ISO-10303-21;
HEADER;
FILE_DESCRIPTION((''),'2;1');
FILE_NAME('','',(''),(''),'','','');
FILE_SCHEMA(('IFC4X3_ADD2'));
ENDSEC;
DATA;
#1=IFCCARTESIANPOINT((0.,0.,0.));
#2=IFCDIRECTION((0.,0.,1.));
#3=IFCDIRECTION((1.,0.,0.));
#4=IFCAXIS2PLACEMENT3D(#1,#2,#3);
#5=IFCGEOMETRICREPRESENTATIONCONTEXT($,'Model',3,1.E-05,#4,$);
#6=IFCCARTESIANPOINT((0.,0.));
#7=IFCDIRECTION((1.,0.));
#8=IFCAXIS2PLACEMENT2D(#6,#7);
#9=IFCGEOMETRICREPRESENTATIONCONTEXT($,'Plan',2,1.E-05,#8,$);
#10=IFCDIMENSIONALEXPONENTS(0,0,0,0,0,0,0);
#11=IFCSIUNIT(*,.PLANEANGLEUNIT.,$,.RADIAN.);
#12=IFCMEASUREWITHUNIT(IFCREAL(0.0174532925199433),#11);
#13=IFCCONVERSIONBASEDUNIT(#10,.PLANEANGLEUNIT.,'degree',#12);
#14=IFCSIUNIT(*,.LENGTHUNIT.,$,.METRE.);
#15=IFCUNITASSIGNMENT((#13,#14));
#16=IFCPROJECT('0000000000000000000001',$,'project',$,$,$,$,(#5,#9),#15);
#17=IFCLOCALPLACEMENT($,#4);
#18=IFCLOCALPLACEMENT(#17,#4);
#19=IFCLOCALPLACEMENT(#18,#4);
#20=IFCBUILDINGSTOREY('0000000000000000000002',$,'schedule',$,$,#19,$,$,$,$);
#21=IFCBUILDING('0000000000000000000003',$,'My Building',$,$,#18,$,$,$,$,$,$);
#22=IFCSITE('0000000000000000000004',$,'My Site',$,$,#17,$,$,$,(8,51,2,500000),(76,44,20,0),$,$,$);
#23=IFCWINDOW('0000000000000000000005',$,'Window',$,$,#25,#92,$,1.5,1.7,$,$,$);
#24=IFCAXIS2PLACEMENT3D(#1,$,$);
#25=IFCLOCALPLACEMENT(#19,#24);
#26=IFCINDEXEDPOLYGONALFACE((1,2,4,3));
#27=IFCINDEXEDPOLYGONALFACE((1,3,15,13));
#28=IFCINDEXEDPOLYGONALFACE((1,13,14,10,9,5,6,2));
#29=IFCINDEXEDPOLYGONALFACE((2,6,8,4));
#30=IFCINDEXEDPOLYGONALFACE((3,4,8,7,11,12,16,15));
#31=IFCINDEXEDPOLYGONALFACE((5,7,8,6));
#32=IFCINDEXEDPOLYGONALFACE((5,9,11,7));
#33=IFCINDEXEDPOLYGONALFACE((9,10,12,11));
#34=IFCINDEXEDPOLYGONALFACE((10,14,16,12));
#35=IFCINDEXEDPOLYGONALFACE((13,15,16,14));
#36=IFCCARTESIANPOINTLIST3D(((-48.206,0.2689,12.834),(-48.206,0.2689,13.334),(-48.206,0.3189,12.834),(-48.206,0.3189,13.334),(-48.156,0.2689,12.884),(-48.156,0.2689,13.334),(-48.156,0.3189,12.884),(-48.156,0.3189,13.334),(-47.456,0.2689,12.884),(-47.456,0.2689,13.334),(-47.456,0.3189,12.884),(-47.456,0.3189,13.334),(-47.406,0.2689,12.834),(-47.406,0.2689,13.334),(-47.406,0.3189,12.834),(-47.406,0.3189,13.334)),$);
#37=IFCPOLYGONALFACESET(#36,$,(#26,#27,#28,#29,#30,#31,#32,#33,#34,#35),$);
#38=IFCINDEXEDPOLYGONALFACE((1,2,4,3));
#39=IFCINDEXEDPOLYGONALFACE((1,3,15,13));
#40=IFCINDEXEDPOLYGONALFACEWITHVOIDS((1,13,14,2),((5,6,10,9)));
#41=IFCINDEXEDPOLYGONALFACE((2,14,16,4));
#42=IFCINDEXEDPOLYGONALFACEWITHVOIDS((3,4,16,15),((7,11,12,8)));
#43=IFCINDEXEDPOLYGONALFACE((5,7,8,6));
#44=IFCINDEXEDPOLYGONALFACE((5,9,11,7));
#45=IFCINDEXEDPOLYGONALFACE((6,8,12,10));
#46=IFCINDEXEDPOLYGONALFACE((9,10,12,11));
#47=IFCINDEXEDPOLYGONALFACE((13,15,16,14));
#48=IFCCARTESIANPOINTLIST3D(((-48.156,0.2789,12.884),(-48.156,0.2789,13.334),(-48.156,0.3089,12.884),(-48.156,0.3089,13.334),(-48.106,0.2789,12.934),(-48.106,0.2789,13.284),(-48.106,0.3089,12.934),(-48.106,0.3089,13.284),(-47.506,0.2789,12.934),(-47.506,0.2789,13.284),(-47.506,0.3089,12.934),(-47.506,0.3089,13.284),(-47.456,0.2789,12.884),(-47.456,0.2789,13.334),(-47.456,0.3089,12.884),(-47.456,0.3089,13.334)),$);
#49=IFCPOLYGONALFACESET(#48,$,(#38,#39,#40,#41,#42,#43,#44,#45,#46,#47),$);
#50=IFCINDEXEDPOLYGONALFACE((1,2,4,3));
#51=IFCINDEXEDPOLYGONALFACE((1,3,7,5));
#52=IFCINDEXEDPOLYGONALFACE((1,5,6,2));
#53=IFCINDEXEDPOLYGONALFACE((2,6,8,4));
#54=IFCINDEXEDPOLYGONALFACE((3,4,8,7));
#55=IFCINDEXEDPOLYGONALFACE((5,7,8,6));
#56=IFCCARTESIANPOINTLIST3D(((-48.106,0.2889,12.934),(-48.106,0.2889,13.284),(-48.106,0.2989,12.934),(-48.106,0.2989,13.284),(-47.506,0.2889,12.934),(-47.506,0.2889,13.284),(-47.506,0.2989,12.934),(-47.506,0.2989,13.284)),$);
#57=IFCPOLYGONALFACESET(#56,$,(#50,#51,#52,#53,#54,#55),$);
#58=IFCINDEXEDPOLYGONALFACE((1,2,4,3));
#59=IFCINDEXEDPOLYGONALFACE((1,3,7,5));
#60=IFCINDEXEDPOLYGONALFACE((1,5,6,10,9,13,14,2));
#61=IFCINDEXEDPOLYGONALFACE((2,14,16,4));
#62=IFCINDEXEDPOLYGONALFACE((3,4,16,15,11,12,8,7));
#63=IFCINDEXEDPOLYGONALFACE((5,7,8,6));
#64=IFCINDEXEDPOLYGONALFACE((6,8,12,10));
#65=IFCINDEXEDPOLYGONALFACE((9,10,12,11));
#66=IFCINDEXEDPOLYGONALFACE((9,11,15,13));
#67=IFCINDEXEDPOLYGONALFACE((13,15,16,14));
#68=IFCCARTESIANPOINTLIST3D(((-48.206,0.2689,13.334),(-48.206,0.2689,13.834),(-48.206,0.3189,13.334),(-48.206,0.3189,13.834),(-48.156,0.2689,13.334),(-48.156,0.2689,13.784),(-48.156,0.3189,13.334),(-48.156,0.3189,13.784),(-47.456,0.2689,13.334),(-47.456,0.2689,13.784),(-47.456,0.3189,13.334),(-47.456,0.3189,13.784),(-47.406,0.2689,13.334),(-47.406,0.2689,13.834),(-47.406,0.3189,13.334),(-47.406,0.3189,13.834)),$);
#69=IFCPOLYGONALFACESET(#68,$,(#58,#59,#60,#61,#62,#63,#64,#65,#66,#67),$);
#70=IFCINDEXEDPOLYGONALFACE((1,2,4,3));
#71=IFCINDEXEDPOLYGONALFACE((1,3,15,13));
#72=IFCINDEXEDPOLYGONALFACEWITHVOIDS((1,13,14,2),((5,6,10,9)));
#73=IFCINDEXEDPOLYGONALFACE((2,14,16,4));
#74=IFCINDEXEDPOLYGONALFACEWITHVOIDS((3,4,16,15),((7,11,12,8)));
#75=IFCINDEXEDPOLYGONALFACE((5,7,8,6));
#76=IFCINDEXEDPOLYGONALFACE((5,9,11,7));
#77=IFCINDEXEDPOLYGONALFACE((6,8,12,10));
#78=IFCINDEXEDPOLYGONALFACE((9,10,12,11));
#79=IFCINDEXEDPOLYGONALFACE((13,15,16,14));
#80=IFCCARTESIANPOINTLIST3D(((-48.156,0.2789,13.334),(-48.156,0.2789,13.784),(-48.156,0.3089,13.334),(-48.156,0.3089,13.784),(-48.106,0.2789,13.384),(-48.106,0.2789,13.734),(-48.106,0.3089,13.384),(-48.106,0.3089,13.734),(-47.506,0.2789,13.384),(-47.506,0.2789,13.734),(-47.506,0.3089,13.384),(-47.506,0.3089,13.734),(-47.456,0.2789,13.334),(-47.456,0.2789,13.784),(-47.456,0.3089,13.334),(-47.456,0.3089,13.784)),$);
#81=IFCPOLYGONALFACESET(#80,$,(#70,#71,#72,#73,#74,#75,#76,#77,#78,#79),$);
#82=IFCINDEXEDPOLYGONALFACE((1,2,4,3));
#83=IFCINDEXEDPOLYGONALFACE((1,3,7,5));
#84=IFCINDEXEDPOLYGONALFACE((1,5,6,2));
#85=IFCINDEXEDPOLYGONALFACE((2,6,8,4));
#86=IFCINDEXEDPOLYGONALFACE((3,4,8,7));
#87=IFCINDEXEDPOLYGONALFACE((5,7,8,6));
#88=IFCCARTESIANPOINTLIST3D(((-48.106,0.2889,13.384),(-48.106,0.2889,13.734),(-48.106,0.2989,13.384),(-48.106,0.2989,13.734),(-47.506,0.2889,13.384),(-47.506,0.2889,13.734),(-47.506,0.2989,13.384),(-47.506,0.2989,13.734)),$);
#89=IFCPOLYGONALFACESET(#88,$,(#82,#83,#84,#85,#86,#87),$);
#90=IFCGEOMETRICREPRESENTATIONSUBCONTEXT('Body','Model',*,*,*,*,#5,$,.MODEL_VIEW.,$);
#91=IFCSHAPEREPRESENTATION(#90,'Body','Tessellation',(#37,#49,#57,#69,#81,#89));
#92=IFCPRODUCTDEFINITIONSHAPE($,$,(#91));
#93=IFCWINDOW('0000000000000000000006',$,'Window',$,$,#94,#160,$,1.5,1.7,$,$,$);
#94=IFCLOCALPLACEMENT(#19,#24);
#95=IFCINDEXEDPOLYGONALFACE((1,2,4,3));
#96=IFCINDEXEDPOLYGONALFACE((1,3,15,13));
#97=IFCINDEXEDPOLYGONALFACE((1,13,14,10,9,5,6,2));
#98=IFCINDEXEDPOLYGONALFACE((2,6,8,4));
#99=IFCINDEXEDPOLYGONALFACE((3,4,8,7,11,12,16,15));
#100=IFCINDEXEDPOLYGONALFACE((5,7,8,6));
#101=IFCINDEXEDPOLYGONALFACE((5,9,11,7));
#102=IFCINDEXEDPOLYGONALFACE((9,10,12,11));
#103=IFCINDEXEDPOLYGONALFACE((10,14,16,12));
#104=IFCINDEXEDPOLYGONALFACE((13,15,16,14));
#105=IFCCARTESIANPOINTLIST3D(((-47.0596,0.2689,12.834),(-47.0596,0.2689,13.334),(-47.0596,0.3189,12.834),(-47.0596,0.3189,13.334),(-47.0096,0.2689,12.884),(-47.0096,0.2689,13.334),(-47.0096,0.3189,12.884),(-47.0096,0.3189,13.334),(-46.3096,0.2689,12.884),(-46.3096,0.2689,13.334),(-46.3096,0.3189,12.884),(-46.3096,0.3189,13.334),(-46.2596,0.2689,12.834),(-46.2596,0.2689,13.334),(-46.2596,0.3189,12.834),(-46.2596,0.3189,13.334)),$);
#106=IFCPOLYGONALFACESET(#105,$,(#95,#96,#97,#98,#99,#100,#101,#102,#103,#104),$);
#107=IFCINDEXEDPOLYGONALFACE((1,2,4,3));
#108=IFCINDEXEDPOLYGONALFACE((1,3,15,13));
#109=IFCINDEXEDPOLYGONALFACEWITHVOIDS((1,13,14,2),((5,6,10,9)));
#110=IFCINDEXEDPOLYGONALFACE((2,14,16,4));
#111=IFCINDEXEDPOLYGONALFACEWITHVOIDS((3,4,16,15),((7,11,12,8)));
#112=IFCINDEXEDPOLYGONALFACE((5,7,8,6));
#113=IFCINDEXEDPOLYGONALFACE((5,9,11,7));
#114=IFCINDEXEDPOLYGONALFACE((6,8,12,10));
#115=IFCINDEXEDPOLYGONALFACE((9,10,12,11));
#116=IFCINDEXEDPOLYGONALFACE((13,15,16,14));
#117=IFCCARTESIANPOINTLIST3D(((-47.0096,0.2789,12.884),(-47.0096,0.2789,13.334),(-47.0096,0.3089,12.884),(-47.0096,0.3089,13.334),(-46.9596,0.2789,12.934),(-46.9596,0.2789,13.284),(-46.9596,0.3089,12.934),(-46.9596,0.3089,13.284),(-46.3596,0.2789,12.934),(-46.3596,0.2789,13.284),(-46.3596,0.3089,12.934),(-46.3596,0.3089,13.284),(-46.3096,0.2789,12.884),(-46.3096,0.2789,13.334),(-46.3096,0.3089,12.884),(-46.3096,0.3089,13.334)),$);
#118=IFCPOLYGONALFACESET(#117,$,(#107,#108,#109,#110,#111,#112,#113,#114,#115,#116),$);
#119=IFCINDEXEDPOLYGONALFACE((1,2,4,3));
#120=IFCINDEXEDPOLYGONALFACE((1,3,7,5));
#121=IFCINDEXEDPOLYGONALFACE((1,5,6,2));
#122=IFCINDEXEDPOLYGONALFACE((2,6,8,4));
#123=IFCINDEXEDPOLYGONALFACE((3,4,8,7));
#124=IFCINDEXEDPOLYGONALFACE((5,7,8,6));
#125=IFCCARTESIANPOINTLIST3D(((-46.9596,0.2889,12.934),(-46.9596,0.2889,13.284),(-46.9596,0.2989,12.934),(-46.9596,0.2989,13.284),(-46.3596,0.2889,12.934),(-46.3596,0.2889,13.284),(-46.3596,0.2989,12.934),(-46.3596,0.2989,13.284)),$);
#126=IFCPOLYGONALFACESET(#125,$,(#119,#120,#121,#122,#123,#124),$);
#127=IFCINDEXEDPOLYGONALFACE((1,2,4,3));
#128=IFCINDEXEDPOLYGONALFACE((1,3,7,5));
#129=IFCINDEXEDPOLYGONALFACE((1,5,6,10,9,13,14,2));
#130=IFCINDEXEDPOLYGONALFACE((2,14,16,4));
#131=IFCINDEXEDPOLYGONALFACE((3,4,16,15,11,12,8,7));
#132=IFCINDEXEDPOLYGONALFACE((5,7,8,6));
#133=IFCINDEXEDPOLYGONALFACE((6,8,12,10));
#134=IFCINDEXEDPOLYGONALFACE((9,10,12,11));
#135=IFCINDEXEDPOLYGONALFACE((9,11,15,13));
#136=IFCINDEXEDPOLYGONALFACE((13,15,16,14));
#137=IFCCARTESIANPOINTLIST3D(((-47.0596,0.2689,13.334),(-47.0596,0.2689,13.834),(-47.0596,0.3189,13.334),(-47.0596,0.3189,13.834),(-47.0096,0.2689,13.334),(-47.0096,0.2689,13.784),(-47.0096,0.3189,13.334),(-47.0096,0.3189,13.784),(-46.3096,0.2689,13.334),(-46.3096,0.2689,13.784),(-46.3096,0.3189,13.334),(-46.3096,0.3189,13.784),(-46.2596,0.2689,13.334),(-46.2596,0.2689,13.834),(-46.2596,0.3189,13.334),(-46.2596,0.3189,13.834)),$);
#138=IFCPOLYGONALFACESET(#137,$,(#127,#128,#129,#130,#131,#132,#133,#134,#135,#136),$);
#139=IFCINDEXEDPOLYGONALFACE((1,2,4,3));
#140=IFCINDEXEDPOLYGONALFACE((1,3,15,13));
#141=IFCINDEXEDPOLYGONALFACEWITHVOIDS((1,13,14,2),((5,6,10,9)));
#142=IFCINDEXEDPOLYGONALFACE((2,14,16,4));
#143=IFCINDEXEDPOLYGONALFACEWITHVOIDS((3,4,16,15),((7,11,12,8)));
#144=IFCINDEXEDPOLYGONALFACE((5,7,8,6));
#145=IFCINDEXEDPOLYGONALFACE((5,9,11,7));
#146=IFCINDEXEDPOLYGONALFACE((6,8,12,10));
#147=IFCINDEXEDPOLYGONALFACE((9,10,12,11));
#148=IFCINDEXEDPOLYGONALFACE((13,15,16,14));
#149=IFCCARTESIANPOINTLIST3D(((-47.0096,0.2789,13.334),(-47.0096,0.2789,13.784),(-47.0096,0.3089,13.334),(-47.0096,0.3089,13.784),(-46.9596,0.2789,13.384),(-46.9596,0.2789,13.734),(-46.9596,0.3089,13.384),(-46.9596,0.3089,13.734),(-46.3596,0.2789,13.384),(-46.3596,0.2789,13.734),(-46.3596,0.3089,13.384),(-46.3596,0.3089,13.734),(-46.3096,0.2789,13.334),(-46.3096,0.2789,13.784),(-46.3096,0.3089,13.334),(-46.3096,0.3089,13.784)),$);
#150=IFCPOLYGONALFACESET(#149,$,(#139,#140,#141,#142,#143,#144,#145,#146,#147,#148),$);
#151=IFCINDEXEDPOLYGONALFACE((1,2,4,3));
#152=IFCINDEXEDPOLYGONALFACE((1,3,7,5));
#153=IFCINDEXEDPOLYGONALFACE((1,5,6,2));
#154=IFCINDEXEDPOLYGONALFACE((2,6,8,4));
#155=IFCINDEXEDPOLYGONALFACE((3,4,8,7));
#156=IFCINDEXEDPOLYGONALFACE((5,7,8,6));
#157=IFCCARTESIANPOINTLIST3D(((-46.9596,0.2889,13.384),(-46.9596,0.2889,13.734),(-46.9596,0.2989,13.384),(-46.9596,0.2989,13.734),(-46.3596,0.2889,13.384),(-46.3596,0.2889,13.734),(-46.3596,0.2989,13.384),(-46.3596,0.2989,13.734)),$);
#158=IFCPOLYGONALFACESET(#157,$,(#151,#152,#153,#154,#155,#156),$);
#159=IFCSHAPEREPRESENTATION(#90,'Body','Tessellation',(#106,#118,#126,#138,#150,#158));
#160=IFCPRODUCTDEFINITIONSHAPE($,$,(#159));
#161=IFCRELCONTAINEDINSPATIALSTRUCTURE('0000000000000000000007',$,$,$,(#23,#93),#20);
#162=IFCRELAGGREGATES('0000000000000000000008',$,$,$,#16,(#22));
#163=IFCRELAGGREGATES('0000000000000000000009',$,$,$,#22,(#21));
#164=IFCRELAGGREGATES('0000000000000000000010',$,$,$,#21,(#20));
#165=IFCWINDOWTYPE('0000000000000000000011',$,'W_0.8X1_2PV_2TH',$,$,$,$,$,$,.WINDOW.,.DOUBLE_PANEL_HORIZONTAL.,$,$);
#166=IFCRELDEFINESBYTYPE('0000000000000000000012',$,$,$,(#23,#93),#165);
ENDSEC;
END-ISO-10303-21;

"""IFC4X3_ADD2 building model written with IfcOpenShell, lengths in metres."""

from ifc_helpers import new_model, entity, si_unit, converted_unit, frame, origin_with_axes, origin_2d_with_axis, place, context, subcontext, project, spatial, line, indexed_curve, outline, extrude, shape, source, transform, mapped, type_object, type_shapes, element, save


model = new_model("IFC4X3_ADD2")

# Units and contexts
model_context = context("Model", 3, precision=1e-05, world=origin_with_axes())
plan_context = context("Plan", 2, precision=1e-05, world=origin_2d_with_axis())
body_context_1 = subcontext(model_context, "Body", "Model", "MODEL_VIEW")
body_context_2 = subcontext(plan_context, "Body", "Plan", "PLAN_VIEW")
ifc_project = project(units=[converted_unit("PLANEANGLEUNIT", "degree", entity("IfcReal", 0.0174532925199433), si_unit("PLANEANGLEUNIT", "RADIAN"), dimensions=[0, 0, 0, 0, 0, 0, 0]), si_unit("LENGTHUNIT", "METRE")], contexts=[model_context, plan_context])

# Site, building, storey
site_placement = place(None, origin_with_axes())
site = spatial("IfcSite", under=ifc_project, at=site_placement, Name="My Site", RefLatitude=(8, 51, 2, 500000), RefLongitude=(76, 44, 20, 0))
building_placement = place(site_placement, origin_with_axes())
building = spatial("IfcBuilding", under=site, at=building_placement, Name="My Building")
storey_placement = place(building_placement, origin_with_axes())
storey = spatial("IfcBuildingStorey", under=building, at=storey_placement, Name="schedule")

# Windows
placement_1 = place(storey_placement, frame((-67.8485, 0.2689, 3.1152), z_axis=(0.0, 0.0, 1.0), x_axis=(1.0, 0.0, 0.0)))
window_type_1 = type_object("IfcWindowType", Name="W_0.8X1_2PV_2TH", PartitioningType="DOUBLE_PANEL_HORIZONTAL", PredefinedType="WINDOW")
shared_shape_1 = source(origin_with_axes(), body_context_1, "Body", "SweptSolid", [
    extrude(outline(indexed_curve([(0.8, 0.5), (0.8, 0.0), (0.0, 0.0), (0.0, 0.5), (0.05, 0.5), (0.05, 0.05), (0.75, 0.05), (0.75, 0.5)], segments=[line(1, 2, 3, 4, 5, 6, 7, 8, 1)])), frame((0.0, 0.0, 0.0), z_axis=(0.0, -1.0, 0.0), x_axis=(1.0, 0.0, 0.0)), (0.0, 0.0, -1.0), 0.05),
    extrude(outline(indexed_curve([(0.0, 0.0), (0.7, 0.0), (0.7, 0.45), (0.0, 0.45)], segments=[line(1, 2, 3, 4, 1)]), holes=[indexed_curve([(0.05, 0.05), (0.65, 0.05), (0.65, 0.4), (0.05, 0.4)], segments=[line(1, 2, 3, 4, 1)])]), frame((0.05, 0.01, 0.05), z_axis=(0.0, -1.0, 0.0), x_axis=(1.0, 0.0, 0.0)), (0.0, 0.0, -1.0), 0.03),
    extrude(outline(indexed_curve([(0.05, 0.05), (0.65, 0.05), (0.65, 0.4), (0.05, 0.4)], segments=[line(1, 2, 3, 4, 1)])), frame((0.05, 0.02, 0.05), z_axis=(0.0, -1.0, 0.0), x_axis=(1.0, 0.0, 0.0)), (0.0, 0.0, -1.0), 0.01),
    extrude(outline(indexed_curve([(0.0, 0.0), (0.0, 0.5), (0.8, 0.5), (0.8, 0.0), (0.75, 0.0), (0.75, 0.45), (0.05, 0.45), (0.05, 0.0)], segments=[line(1, 2, 3, 4, 5, 6, 7, 8, 1)])), frame((0.0, 0.0, 0.5), z_axis=(0.0, -1.0, 0.0), x_axis=(1.0, 0.0, 0.0)), (0.0, 0.0, -1.0), 0.05),
    extrude(outline(indexed_curve([(0.0, 0.0), (0.7, 0.0), (0.7, 0.45), (0.0, 0.45)], segments=[line(1, 2, 3, 4, 1)]), holes=[indexed_curve([(0.05, 0.05), (0.65, 0.05), (0.65, 0.4), (0.05, 0.4)], segments=[line(1, 2, 3, 4, 1)])]), frame((0.05, 0.01, 0.5), z_axis=(0.0, -1.0, 0.0), x_axis=(1.0, 0.0, 0.0)), (0.0, 0.0, -1.0), 0.03),
    extrude(outline(indexed_curve([(0.05, 0.05), (0.65, 0.05), (0.65, 0.4), (0.05, 0.4)], segments=[line(1, 2, 3, 4, 1)])), frame((0.05, 0.02, 0.5), z_axis=(0.0, -1.0, 0.0), x_axis=(1.0, 0.0, 0.0)), (0.0, 0.0, -1.0), 0.01),
])
shared_shape_2 = source(origin_with_axes(), body_context_2, "Body", "Curve2D", [
    entity("IfcIndexedPolyCurve", entity("IfcCartesianPointList2D", [[0.05, 0.0], [0.75, 0.0]])),
    entity("IfcIndexedPolyCurve", entity("IfcCartesianPointList2D", [[0.0, 0.05], [0.05, 0.05], [0.05, 0.0], [0.0, 0.0]]), [entity("IfcLineIndex", [1, 2, 3, 4, 1])]),
    entity("IfcIndexedPolyCurve", entity("IfcCartesianPointList2D", [[0.8, 0.05], [0.75, 0.05], [0.75, 0.0], [0.8, 0.0]]), [entity("IfcLineIndex", [1, 2, 3, 4, 1])]),
    entity("IfcIndexedPolyCurve", entity("IfcCartesianPointList2D", [[0.05, 0.01], [0.1, 0.01], [0.1, 0.04], [0.05, 0.04]]), [entity("IfcLineIndex", [1, 2, 3, 4, 1])]),
    entity("IfcIndexedPolyCurve", entity("IfcCartesianPointList2D", [[0.75, 0.01], [0.7, 0.01], [0.7, 0.04], [0.75, 0.04]]), [entity("IfcLineIndex", [1, 2, 3, 4, 1])]),
    entity("IfcIndexedPolyCurve", entity("IfcCartesianPointList2D", [[0.1, 0.01], [0.7, 0.01]])),
    entity("IfcIndexedPolyCurve", entity("IfcCartesianPointList2D", [[0.1, 0.04], [0.7, 0.04]])),
    entity("IfcIndexedPolyCurve", entity("IfcCartesianPointList2D", [[0.1, 0.025], [0.7, 0.025]])),
])
type_shapes(window_type_1, [shared_shape_1, shared_shape_2])
placement_2 = place(placement_1, frame((19.6425, 0.0, 9.7188), z_axis=(0.0, 0.0, 1.0), x_axis=(1.0, 0.0, 0.0)))
window_1_placement = place(placement_2, origin_with_axes())
element("IfcWindow", 1, at=window_1_placement, inside=storey, type_object=window_type_1, Name="Window", OverallHeight=1.5, OverallWidth=1.7, shapes=[
    shape(body_context_1, "Body", "MappedRepresentation", [mapped(shared_shape_1, transform((0.0, 0.0, 0.0), x_axis=(1.0, 0.0, 0.0), y_axis=(0.0, 1.0, 0.0), z_axis=(0.0, 0.0, 1.0), scale=1.0))]),
    shape(body_context_2, "Body", "MappedRepresentation", [mapped(shared_shape_2, transform((0.0, 0.0, 0.0), x_axis=(1.0, 0.0, 0.0), y_axis=(0.0, 1.0, 0.0), z_axis=(0.0, 0.0, 1.0), scale=1.0))]),
])
placement_3 = place(placement_1, frame((20.7889, 0.0, 9.7188), z_axis=(0.0, 0.0, 1.0), x_axis=(1.0, 0.0, 0.0)))
window_2_placement = place(placement_3, origin_with_axes())
element("IfcWindow", 2, at=window_2_placement, inside=storey, type_object=window_type_1, Name="Window", OverallHeight=1.5, OverallWidth=1.7, shapes=[
    shape(body_context_1, "Body", "MappedRepresentation", [mapped(shared_shape_1, transform((0.0, 0.0, 0.0), x_axis=(1.0, 0.0, 0.0), y_axis=(0.0, 1.0, 0.0), z_axis=(0.0, 0.0, 1.0), scale=1.0))]),
    shape(body_context_2, "Body", "MappedRepresentation", [mapped(shared_shape_2, transform((0.0, 0.0, 0.0), x_axis=(1.0, 0.0, 0.0), y_axis=(0.0, 1.0, 0.0), z_axis=(0.0, 0.0, 1.0), scale=1.0))]),
])

save(model, "model.ifc")
